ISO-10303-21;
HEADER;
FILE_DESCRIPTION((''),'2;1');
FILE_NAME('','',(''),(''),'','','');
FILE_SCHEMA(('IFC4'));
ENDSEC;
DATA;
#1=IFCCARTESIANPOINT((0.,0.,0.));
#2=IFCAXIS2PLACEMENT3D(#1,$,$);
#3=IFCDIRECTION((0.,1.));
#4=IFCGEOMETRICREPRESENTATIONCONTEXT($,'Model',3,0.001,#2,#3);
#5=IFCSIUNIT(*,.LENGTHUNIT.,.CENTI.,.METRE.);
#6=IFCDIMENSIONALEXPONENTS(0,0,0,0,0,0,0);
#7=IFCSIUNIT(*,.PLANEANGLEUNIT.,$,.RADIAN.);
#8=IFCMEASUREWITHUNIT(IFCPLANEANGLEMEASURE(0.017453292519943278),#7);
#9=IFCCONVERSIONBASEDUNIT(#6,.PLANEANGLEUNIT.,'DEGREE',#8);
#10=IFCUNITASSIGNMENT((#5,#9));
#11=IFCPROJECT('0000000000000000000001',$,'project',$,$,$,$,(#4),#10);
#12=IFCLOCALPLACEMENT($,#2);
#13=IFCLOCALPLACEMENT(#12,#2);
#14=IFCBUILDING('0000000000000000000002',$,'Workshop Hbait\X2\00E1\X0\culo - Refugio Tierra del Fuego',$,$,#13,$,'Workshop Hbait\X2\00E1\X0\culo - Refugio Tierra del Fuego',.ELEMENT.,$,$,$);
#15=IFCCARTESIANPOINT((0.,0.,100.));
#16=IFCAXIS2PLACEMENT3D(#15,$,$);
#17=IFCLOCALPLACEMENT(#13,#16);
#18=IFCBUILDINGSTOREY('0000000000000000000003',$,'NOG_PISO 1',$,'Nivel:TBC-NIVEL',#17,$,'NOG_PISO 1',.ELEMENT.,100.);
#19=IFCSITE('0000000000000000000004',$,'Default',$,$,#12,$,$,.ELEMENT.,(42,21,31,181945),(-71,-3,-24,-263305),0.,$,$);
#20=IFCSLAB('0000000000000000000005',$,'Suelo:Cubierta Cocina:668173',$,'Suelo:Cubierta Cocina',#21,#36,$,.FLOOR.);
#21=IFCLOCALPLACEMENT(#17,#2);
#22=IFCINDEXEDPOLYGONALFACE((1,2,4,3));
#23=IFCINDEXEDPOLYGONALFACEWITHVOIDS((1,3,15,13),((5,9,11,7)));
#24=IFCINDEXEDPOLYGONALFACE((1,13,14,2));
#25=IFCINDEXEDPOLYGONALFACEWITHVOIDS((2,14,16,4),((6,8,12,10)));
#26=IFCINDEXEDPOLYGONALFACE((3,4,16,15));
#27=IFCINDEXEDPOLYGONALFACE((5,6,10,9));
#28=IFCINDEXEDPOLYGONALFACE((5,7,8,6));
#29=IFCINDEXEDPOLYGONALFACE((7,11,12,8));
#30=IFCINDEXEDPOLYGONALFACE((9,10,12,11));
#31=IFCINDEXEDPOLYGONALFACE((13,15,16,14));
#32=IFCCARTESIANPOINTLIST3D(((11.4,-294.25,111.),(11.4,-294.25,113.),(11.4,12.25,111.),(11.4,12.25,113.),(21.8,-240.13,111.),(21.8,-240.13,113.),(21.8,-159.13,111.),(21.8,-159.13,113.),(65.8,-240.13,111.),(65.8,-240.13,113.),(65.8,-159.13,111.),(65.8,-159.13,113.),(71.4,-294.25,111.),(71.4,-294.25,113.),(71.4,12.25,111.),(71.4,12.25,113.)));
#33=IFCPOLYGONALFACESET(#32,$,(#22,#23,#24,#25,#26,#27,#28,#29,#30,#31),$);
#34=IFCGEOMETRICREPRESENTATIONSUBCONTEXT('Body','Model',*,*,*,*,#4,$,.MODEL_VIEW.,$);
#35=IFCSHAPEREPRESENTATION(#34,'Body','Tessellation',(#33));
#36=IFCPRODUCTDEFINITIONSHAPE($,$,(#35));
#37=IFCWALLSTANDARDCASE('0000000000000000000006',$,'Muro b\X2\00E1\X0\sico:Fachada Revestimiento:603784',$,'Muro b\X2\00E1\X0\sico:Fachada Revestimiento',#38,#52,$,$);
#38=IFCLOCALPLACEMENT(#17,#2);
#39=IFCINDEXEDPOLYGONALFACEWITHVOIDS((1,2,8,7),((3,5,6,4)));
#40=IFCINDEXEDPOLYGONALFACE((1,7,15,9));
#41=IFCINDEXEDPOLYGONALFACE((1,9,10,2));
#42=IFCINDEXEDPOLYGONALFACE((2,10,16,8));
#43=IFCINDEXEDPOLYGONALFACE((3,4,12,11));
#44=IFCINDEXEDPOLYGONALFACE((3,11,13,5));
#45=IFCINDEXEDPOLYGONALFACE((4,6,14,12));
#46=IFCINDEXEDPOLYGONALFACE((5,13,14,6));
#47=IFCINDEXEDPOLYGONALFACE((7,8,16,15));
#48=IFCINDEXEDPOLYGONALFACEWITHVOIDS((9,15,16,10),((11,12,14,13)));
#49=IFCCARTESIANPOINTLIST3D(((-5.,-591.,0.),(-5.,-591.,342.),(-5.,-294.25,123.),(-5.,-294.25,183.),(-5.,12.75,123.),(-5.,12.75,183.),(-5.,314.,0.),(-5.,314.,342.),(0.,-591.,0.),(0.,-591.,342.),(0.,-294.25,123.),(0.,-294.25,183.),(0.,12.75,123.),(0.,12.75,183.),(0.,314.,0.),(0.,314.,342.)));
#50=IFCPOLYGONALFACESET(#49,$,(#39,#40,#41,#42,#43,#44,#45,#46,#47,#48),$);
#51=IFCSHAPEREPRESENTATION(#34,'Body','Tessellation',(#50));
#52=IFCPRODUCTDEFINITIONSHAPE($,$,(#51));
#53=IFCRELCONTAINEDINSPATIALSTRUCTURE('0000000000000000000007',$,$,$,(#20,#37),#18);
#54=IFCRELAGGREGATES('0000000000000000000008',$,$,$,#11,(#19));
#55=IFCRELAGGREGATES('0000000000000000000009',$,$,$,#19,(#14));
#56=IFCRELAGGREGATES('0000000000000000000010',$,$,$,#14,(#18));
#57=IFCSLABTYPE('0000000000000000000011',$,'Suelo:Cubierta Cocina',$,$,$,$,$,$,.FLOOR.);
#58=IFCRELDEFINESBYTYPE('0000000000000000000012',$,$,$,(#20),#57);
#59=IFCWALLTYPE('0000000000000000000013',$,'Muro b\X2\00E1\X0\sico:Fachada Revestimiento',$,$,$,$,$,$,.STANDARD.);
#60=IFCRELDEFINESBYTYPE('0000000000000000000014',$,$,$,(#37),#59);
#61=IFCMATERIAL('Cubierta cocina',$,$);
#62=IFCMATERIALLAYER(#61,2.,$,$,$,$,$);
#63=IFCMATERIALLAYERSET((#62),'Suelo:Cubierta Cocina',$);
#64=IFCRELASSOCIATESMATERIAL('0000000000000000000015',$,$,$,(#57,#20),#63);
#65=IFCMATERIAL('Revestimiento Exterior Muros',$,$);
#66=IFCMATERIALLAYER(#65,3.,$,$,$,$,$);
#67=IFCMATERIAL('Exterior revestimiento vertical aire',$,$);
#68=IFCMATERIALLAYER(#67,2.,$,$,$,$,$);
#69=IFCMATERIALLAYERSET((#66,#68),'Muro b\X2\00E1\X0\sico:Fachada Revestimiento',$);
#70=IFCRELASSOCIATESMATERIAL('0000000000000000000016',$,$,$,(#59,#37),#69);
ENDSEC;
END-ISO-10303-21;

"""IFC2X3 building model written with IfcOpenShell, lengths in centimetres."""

from ifc_helpers import new_model, entity, si_unit, converted_unit, direction, frame, frame_2d, origin, origin_2d_with_axis, place, context, subcontext, project, spatial, rectangle, extrude, boolean, material, layer, layer_set, layer_usage, type_object, element, save


model = new_model("IFC2X3")

# Units and contexts
model_context = context("Model", 3, precision=0.001, world=origin(), true_north=direction((0.0, 1.0)))
body_context = subcontext(model_context, "Body", "Model", "MODEL_VIEW")
ifc_project = project(units=[si_unit("LENGTHUNIT", "METRE", prefix="CENTI"), converted_unit("PLANEANGLEUNIT", "DEGREE", entity("IfcPlaneAngleMeasure", 0.017453292519943278), si_unit("PLANEANGLEUNIT", "RADIAN"), dimensions=[0, 0, 0, 0, 0, 0, 0])], contexts=[model_context])

# Site, building, storey
site_placement = place(None, origin())
site = spatial("IfcSite", under=ifc_project, at=site_placement, Name="Default", CompositionType="ELEMENT", RefLatitude=(42, 21, 31, 181945), RefLongitude=(-71, -3, -24, -263305), RefElevation=0.0)
building_placement = place(site_placement, origin())
building = spatial("IfcBuilding", under=site, at=building_placement, Name="Workshop Hbaitáculo - Refugio Tierra del Fuego", LongName="Workshop Hbaitáculo - Refugio Tierra del Fuego", CompositionType="ELEMENT")
storey_placement = place(building_placement, frame((0.0, 0.0, 100.0)))
storey = spatial("IfcBuildingStorey", under=building, at=storey_placement, Name="NOG_PISO 1", ObjectType="Nivel:TBC-NIVEL", LongName="NOG_PISO 1", CompositionType="ELEMENT", Elevation=100.0)

# Slab, opening
ifc_material_1 = material(Name="Cubierta cocina")
ifc_layer_1 = layer(ifc_material_1, 2.0)
ifc_layer_set_1 = layer_set([ifc_layer_1], Name="Suelo:Cubierta Cocina")
ifc_layer_usage_1 = layer_usage(ifc_layer_set_1, "AXIS3", "POSITIVE", 0.0)
slab_type_1 = type_object("IfcSlabType", Name="Suelo:Cubierta Cocina", PredefinedType="FLOOR", material=ifc_layer_set_1)
slab_1_placement = place(storey_placement, origin())
slab_1 = element("IfcSlab", 1, at=slab_1_placement, inside=storey, type_object=slab_type_1, material=ifc_layer_usage_1, Name="Suelo:Cubierta Cocina:668173", ObjectType="Suelo:Cubierta Cocina", PredefinedType="FLOOR", context=body_context, shape_type="CSG", body=[
    boolean("DIFFERENCE", extrude(rectangle(XDim=306.5, YDim=60.0, at=origin_2d_with_axis()), frame((41.4, -141.0, 113.0), z_axis=(0.0, 0.0, -1.0), x_axis=(0.0, 1.0, 0.0)), (0.0, 0.0, 1.0), 2.0), extrude(rectangle(XDim=81.0, YDim=44.0, at=frame_2d((0.0, 0.0), x_axis=(1.0, 0.0))), frame((43.8, -199.63, 111.0), z_axis=(0.0, 0.0, 1.0), x_axis=(0.0, 1.0, 0.0)), (0.0, 0.0, 1.0), 2.0)),
])
opening_1_placement = place(slab_1_placement, origin())
element("IfcOpeningElement", 2, at=opening_1_placement, cuts=slab_1, ObjectType="Opening", context=body_context, shape_type="SweptSolid", body=[
    extrude(rectangle(XDim=81.0, YDim=44.0, at=frame_2d((43.8, -199.63), x_axis=(0.0, 1.0))), frame((0.0, 0.0, 113.0)), (0.0, 0.0, -1.0), 2.0),
])

# Wall, opening
ifc_material_2 = material(Name="Revestimiento Exterior Muros")
ifc_layer_2 = layer(ifc_material_2, 3.0)
ifc_material_3 = material(Name="Exterior revestimiento vertical aire")
ifc_layer_3 = layer(ifc_material_3, 2.0)
ifc_layer_set_2 = layer_set([ifc_layer_2, ifc_layer_3], Name="Muro básico:Fachada Revestimiento")
ifc_layer_usage_2 = layer_usage(ifc_layer_set_2, "AXIS2", "POSITIVE", -2.5)
wall_type = type_object("IfcWallType", Name="Muro básico:Fachada Revestimiento", PredefinedType="STANDARD", material=ifc_layer_set_2)
wall_placement = place(storey_placement, frame((-2.5, 314.0, 0.0), z_axis=(0.0, 0.0, 1.0), x_axis=(0.0, -1.0, 0.0)))
wall = element("IfcWallStandardCase", 3, at=wall_placement, inside=storey, type_object=wall_type, material=ifc_layer_usage_2, Name="Muro básico:Fachada Revestimiento:603784", ObjectType="Muro básico:Fachada Revestimiento", context=body_context, shape_type="SweptSolid", body=[
    extrude(rectangle(XDim=905.0, YDim=5.0, at=frame_2d((452.5, 0.0), x_axis=(-1.0, 0.0))), origin(), (0.0, 0.0, 1.0), 342.0),
])
opening_2_placement = place(wall_placement, origin())
element("IfcOpeningElement", 4, at=opening_2_placement, cuts=wall, ObjectType="Opening", context=body_context, shape_type="SweptSolid", body=[
    extrude(rectangle(XDim=60.0, YDim=307.0, at=frame_2d((0.0, 0.0), x_axis=(0.0, 1.0))), frame((454.75, 2.5, 153.0), z_axis=(0.0, -1.0, 0.0), x_axis=(1.0, 0.0, 0.0)), (0.0, 0.0, 1.0), 5.0),
])

save(model, "model.ifc")
